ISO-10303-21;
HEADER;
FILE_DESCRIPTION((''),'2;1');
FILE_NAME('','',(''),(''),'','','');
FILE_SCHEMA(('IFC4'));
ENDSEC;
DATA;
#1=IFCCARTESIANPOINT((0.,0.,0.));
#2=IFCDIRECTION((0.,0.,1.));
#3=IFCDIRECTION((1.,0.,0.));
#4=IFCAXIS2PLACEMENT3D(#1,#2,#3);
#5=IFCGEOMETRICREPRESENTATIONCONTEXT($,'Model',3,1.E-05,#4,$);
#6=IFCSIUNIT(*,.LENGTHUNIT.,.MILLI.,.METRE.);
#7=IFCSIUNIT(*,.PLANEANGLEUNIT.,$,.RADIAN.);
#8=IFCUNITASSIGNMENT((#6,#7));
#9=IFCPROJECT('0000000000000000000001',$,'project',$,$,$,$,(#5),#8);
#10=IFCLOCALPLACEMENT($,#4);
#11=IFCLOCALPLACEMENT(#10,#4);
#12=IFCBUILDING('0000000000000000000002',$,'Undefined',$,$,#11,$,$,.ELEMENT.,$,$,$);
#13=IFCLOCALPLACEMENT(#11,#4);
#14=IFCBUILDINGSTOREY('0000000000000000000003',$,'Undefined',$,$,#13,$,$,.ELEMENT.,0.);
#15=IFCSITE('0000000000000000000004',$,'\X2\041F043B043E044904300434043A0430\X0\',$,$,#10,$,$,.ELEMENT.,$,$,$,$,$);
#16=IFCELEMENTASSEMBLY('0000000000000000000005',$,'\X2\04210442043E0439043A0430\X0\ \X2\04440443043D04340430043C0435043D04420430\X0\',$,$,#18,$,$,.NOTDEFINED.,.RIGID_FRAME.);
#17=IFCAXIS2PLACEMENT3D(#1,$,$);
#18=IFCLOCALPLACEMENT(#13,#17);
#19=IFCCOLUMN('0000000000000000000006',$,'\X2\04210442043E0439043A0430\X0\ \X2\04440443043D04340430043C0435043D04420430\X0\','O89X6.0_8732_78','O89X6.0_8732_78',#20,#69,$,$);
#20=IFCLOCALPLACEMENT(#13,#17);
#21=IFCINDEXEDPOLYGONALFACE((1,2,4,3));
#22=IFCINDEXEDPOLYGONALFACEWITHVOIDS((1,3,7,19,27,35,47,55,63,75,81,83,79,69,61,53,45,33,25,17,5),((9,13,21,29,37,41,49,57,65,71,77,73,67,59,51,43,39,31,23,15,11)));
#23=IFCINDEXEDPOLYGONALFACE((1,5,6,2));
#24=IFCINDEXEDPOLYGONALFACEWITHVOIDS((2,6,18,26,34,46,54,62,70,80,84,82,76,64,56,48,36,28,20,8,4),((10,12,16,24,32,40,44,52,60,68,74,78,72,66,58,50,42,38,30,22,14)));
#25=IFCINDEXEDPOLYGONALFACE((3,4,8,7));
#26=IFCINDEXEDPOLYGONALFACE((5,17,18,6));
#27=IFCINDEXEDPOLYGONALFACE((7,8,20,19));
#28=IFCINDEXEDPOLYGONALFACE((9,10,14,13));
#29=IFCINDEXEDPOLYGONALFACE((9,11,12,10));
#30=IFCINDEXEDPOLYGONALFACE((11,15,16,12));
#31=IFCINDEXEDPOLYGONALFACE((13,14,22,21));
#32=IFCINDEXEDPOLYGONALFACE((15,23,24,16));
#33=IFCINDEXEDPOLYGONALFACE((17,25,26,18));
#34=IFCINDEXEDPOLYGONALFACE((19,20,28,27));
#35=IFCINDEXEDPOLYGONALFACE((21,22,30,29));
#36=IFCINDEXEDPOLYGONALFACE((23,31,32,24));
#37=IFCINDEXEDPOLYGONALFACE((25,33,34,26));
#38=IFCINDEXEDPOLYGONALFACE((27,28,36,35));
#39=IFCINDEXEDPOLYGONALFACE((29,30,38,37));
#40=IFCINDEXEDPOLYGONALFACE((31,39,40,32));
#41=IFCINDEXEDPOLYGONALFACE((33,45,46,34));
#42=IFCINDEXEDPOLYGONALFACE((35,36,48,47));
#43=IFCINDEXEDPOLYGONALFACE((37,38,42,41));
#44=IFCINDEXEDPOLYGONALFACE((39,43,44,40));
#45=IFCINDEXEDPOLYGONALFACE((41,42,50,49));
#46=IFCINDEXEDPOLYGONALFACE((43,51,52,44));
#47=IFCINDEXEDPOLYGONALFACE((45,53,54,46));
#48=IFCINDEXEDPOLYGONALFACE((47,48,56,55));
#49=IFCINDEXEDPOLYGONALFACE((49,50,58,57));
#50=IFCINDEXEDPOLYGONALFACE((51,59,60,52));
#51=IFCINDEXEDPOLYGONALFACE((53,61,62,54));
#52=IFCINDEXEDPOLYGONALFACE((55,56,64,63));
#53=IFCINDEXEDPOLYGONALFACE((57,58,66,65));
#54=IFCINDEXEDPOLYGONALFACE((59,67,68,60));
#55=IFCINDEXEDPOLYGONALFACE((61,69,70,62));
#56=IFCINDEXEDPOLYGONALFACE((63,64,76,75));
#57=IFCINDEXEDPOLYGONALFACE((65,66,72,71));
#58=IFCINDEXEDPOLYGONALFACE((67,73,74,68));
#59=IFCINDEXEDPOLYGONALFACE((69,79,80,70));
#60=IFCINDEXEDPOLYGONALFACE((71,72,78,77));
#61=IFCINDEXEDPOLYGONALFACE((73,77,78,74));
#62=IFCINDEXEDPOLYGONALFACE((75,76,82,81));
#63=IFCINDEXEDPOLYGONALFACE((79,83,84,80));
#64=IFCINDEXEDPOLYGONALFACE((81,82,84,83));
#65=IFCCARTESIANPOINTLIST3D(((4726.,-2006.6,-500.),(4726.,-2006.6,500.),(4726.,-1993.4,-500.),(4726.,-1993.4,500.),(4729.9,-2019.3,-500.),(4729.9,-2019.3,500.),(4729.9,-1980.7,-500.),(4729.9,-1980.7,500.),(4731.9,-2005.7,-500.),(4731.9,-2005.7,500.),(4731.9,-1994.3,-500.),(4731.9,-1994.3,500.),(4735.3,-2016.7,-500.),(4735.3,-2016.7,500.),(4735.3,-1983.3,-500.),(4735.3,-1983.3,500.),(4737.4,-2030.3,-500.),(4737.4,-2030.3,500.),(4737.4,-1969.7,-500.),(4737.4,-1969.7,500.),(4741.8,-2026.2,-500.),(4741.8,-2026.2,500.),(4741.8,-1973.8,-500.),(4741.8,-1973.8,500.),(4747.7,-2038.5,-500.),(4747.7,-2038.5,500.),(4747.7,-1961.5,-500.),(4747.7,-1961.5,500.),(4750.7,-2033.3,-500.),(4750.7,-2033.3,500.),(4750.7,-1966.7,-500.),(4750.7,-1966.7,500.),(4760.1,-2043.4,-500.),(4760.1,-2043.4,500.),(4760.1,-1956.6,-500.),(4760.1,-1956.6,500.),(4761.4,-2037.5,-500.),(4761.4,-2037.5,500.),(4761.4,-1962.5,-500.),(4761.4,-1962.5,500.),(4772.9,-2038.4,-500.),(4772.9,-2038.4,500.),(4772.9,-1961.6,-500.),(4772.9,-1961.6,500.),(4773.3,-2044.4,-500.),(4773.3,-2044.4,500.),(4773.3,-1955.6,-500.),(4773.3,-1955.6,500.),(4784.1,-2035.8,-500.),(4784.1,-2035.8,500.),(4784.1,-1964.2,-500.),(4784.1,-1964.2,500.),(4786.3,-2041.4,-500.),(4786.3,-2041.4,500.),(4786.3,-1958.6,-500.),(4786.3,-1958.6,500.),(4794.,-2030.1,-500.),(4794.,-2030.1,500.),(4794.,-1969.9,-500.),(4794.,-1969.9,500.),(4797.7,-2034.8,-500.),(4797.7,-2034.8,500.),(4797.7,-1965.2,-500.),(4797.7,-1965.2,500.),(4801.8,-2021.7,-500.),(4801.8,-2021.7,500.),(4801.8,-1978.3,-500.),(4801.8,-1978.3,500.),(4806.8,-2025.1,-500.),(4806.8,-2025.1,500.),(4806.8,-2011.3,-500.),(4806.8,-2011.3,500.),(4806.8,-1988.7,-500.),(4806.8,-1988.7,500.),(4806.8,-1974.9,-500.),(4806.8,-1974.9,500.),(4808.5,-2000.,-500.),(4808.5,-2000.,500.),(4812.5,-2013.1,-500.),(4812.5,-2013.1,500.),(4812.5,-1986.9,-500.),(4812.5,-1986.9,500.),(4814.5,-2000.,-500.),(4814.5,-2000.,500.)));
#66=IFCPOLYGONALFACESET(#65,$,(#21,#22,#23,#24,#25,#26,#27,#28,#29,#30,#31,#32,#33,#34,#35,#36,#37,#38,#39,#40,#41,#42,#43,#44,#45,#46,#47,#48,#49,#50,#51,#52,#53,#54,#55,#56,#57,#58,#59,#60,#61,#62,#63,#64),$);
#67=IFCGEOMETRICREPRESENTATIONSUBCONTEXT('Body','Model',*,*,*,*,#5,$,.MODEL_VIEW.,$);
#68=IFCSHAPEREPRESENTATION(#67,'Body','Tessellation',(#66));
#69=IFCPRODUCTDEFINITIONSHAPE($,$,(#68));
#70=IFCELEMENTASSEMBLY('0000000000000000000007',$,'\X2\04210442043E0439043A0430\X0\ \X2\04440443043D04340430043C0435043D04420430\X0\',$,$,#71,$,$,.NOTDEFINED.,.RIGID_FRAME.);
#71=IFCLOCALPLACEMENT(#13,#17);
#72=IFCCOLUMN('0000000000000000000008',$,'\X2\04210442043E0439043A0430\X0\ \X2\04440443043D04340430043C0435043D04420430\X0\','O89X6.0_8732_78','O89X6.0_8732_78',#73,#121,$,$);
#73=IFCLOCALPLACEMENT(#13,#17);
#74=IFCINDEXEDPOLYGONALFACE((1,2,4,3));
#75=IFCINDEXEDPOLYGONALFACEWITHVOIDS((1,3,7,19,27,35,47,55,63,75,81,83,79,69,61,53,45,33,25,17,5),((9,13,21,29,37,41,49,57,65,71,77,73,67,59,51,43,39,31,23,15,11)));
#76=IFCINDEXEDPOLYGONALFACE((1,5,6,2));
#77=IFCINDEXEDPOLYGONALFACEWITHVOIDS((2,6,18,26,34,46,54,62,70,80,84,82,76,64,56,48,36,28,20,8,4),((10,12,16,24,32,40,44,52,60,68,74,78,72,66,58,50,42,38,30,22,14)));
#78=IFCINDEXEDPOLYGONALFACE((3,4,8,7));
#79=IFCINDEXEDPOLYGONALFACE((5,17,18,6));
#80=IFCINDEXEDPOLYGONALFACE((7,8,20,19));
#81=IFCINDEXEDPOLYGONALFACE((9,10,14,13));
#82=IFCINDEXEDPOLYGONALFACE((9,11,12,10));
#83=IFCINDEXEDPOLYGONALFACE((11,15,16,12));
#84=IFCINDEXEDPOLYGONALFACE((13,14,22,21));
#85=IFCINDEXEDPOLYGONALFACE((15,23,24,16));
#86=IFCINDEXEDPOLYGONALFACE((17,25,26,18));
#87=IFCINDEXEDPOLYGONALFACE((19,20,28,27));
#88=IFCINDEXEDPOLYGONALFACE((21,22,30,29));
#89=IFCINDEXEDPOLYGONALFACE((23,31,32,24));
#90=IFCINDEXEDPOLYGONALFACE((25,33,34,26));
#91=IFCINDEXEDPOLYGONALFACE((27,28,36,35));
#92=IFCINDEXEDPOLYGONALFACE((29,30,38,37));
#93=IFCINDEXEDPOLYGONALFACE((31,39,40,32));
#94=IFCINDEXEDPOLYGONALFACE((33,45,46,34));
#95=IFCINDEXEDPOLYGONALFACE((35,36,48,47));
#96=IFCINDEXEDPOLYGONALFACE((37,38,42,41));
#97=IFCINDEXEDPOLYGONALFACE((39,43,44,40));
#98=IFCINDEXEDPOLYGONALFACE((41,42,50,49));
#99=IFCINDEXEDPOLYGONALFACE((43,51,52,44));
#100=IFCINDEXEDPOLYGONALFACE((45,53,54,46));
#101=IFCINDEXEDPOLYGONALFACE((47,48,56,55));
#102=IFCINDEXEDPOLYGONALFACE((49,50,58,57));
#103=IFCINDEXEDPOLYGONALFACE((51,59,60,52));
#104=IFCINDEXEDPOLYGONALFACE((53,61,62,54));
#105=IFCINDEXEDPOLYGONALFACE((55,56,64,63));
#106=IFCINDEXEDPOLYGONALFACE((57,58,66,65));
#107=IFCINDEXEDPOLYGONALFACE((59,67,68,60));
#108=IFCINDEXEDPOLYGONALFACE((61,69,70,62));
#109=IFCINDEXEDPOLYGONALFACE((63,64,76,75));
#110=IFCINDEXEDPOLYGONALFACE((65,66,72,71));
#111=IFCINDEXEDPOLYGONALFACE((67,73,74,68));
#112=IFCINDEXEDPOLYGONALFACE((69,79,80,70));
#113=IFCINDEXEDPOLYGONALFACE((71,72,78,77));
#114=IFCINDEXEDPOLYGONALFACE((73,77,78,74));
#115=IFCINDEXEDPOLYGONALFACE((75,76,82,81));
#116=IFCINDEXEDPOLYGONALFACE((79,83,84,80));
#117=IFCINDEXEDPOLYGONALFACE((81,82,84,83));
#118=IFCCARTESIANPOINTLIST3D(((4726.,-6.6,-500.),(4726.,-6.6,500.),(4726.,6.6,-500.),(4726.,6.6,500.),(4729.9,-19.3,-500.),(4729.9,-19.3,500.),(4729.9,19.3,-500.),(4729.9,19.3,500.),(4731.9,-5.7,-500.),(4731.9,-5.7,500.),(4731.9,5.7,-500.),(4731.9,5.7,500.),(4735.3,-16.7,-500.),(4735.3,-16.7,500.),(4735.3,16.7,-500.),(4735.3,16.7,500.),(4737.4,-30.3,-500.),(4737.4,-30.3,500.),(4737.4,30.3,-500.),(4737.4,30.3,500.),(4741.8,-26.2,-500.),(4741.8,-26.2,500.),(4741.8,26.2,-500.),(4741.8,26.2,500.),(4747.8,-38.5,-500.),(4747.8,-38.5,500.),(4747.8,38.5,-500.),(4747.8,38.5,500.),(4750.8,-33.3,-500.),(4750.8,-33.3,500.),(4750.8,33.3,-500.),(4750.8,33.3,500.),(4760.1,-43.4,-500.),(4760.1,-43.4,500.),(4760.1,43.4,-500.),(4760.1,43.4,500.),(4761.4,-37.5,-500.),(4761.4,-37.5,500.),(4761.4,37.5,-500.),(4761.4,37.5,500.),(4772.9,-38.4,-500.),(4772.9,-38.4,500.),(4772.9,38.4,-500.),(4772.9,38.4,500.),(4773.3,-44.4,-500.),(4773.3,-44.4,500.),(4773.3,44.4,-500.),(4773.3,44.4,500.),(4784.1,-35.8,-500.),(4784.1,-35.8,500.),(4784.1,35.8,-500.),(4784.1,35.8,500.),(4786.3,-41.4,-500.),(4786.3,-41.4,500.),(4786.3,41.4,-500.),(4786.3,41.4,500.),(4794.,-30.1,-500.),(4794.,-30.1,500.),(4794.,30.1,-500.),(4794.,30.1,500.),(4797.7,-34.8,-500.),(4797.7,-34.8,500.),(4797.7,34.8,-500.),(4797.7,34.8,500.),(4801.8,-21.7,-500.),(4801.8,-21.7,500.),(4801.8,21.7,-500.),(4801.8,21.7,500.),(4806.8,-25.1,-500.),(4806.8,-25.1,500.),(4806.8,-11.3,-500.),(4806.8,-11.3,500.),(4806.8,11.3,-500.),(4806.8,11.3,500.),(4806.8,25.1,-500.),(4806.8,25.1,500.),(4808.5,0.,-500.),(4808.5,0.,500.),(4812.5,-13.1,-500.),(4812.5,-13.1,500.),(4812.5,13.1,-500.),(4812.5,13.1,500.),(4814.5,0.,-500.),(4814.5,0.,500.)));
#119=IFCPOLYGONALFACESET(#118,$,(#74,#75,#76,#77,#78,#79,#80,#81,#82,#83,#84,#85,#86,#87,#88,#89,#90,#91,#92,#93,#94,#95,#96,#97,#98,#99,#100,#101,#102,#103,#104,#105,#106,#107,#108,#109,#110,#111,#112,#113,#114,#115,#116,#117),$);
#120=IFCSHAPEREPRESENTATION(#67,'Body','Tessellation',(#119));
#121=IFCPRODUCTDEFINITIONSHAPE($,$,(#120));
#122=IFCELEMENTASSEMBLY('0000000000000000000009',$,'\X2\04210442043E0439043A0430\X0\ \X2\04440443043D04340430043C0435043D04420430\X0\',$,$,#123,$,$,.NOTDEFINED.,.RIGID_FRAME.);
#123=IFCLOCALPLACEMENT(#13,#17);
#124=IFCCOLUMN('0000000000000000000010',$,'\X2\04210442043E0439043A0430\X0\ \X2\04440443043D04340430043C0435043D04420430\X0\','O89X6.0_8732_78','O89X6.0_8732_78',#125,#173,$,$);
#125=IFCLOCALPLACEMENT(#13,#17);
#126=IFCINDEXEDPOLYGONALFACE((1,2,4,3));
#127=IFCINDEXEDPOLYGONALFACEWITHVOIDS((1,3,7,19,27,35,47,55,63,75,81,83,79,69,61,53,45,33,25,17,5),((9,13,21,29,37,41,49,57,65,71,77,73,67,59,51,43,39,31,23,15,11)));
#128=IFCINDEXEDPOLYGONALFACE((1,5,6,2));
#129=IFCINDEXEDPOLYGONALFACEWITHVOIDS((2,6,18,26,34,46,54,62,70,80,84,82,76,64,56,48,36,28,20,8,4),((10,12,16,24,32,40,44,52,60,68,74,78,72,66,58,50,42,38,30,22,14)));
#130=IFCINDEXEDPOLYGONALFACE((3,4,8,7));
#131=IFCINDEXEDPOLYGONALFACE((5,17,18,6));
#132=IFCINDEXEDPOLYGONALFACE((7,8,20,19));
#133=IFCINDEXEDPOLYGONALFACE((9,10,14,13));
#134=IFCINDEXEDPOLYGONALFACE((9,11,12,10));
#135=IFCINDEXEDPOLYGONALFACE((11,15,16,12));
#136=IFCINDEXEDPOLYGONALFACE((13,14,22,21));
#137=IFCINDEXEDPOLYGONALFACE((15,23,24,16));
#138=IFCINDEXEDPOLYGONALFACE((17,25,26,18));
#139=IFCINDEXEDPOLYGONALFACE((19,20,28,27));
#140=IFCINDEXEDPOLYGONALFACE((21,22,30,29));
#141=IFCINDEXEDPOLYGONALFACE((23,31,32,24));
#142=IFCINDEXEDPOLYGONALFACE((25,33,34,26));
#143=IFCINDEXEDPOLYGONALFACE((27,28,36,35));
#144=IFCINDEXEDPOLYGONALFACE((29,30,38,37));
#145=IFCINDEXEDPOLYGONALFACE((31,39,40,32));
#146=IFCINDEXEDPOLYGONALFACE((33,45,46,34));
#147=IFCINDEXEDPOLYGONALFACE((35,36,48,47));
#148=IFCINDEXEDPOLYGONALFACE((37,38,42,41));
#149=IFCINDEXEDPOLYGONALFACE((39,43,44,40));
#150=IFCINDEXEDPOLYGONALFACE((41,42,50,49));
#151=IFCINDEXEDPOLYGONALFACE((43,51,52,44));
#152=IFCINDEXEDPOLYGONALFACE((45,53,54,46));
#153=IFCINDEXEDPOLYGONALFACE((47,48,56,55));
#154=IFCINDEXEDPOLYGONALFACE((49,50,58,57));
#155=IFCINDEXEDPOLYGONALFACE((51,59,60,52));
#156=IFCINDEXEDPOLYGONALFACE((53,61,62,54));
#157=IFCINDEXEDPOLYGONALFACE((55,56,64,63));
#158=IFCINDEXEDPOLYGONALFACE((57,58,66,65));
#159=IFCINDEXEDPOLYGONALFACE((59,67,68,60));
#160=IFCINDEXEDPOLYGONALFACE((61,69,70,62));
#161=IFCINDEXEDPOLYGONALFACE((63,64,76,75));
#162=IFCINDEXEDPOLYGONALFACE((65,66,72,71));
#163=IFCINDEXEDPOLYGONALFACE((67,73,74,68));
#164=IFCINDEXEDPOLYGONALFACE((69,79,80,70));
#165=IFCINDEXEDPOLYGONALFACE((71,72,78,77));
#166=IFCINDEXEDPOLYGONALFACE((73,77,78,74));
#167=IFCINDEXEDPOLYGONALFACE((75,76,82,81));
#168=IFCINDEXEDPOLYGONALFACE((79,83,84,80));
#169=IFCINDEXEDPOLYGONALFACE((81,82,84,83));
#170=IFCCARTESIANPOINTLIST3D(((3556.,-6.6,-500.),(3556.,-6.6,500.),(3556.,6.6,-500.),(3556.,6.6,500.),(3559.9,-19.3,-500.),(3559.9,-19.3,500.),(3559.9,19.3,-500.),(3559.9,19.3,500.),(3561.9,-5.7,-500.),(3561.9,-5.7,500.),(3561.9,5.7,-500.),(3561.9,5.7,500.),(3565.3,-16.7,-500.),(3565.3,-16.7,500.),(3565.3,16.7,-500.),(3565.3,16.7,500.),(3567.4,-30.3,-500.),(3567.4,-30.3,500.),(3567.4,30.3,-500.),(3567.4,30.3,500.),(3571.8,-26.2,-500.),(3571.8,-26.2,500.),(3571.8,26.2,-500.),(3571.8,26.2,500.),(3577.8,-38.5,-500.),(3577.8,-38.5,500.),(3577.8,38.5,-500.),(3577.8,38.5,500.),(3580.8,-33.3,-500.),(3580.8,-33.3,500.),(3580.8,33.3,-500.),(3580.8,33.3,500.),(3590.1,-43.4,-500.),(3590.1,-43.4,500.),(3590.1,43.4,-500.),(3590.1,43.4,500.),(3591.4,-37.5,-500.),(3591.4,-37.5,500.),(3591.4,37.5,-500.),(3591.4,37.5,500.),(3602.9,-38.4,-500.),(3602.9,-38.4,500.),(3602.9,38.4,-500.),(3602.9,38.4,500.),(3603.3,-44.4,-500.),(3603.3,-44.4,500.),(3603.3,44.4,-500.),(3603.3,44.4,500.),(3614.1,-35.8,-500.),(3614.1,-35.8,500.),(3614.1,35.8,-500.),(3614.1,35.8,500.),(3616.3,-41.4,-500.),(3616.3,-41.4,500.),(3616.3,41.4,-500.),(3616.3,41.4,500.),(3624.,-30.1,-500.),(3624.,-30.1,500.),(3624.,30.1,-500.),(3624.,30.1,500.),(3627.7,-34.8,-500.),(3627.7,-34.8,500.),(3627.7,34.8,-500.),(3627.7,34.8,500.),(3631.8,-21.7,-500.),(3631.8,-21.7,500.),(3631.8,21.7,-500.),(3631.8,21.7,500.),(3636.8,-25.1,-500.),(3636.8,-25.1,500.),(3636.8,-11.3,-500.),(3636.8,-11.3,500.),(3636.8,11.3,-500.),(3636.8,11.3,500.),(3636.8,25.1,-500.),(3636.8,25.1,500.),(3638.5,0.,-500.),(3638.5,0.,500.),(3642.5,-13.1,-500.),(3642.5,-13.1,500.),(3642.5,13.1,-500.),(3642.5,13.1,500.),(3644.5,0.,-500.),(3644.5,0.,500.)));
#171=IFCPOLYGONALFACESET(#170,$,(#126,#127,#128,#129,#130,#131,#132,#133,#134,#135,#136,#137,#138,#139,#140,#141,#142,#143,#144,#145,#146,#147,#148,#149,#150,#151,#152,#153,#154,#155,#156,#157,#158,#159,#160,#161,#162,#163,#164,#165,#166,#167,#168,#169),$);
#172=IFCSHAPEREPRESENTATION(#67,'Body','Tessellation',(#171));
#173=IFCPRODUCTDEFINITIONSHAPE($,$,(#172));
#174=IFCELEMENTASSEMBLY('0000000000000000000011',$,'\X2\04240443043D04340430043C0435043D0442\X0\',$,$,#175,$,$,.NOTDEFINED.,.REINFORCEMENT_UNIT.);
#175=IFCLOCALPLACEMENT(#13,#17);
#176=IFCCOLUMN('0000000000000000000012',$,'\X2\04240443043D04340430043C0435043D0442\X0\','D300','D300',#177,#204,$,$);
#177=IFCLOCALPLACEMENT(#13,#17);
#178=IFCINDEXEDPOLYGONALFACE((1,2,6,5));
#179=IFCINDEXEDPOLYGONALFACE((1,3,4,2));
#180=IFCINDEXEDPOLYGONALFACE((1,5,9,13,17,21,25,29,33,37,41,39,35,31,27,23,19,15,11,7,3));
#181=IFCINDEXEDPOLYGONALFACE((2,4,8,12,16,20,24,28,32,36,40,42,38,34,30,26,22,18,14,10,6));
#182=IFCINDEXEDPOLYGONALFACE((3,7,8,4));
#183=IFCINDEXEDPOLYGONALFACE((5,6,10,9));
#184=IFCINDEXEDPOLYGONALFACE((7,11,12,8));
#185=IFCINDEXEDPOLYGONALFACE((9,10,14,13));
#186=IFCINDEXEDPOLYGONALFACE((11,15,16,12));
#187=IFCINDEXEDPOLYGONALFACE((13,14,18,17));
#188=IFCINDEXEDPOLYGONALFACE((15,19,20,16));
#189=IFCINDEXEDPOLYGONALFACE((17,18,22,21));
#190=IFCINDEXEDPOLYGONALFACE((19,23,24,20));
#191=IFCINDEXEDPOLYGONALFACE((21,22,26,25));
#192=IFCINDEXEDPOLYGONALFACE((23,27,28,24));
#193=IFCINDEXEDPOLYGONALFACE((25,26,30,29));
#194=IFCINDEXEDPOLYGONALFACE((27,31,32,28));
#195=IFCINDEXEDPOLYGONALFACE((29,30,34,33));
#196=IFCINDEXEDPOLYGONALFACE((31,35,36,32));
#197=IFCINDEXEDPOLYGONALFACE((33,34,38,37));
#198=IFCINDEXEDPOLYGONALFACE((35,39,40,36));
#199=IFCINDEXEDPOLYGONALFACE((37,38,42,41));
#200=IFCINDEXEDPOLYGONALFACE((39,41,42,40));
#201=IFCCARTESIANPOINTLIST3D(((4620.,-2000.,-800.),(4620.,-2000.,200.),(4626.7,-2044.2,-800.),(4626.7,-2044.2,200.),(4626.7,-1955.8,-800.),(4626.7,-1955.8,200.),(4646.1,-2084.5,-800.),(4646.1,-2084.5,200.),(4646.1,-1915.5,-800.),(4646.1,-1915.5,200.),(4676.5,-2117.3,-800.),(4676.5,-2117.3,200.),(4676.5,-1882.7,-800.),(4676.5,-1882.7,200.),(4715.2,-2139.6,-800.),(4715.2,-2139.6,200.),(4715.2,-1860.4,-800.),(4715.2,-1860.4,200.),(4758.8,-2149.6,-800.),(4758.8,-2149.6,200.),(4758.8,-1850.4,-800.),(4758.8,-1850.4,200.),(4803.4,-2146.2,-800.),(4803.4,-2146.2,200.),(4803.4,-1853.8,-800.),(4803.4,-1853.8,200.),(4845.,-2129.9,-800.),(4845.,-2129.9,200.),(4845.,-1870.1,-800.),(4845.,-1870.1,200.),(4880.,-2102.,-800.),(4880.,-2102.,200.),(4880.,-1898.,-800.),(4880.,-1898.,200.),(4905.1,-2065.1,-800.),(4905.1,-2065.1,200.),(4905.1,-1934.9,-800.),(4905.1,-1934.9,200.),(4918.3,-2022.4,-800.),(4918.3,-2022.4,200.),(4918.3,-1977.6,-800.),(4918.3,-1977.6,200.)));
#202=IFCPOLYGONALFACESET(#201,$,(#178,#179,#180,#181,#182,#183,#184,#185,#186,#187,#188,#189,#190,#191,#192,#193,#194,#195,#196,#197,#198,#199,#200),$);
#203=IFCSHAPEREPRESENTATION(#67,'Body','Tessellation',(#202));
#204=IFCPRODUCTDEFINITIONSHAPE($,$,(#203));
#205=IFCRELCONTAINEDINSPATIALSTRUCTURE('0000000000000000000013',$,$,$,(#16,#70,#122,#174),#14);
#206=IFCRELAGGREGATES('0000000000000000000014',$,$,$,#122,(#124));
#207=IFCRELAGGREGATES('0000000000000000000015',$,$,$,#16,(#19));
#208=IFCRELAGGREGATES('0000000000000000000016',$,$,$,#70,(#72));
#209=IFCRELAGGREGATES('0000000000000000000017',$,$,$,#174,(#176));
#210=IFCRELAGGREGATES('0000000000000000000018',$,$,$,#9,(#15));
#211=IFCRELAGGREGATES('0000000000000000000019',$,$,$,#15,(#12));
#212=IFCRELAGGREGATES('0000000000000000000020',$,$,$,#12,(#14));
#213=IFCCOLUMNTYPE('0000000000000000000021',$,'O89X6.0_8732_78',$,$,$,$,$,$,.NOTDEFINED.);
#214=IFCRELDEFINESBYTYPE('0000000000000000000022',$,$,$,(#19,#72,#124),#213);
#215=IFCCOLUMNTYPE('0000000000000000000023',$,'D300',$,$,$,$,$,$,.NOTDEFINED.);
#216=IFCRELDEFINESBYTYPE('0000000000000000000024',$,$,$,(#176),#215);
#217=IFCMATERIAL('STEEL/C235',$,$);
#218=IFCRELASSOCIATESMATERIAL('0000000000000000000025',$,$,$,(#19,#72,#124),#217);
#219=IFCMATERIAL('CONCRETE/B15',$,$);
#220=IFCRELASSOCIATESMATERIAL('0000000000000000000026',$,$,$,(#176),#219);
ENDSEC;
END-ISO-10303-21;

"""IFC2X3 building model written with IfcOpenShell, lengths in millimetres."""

from ifc_helpers import new_model, si_unit, frame, origin_with_axes, origin_2d_with_axis, place, context, subcontext, project, spatial, circle, hollow_circle, extrude, material, type_object, element, aggregate, save


model = new_model("IFC2X3")

# Units and contexts
model_context = context("Model", 3, precision=1e-05, world=origin_with_axes())
body_context = subcontext(model_context, "Body", "Model", "MODEL_VIEW")
ifc_project = project(units=[si_unit("LENGTHUNIT", "METRE", prefix="MILLI"), si_unit("PLANEANGLEUNIT", "RADIAN")], contexts=[model_context])

# Site, building, storey
site_placement = place(None, origin_with_axes())
site = spatial("IfcSite", under=ifc_project, at=site_placement, Name="Площадка", CompositionType="ELEMENT")
building_placement = place(site_placement, origin_with_axes())
building = spatial("IfcBuilding", under=site, at=building_placement, Name="Undefined", CompositionType="ELEMENT")
storey_placement = place(building_placement, origin_with_axes())
storey = spatial("IfcBuildingStorey", under=building, at=storey_placement, Name="Undefined", CompositionType="ELEMENT", Elevation=0.0)

# Element assemblies, columns
assembly_1_placement = place(storey_placement, origin_with_axes())
assembly_1 = element("IfcElementAssembly", 1, at=assembly_1_placement, inside=storey, Name="Стойка фундамента", AssemblyPlace="NOTDEFINED", PredefinedType="RIGID_FRAME")
ifc_material_1 = material(Name="STEEL/C235")
column_type_1 = type_object("IfcColumnType", Name="O89X6.0_8732_78", PredefinedType="NOTDEFINED")
column_1_placement = place(assembly_1_placement, frame((4770.0, -2000.0, -500.0), z_axis=(0.0, 0.0, 1.0), x_axis=(0.0, -1.0, 0.0)))
column_1 = element("IfcColumn", 2, at=column_1_placement, type_object=column_type_1, material=ifc_material_1, Name="Стойка фундамента", Description="O89X6.0_8732_78", ObjectType="O89X6.0_8732_78", context=body_context, shape_type="SweptSolid", body=[
    extrude(hollow_circle(Radius=44.5, WallThickness=6.0, at=origin_2d_with_axis()), frame((0.0, 0.0, 1000.0), z_axis=(0.0, 0.0, -1.0), x_axis=(0.0, 1.0, 0.0)), (0.0, 0.0, 1.0), 1000.0),
])
assembly_2_placement = place(storey_placement, origin_with_axes())
assembly_2 = element("IfcElementAssembly", 3, at=assembly_2_placement, inside=storey, Name="Стойка фундамента", AssemblyPlace="NOTDEFINED", PredefinedType="RIGID_FRAME")
column_2_placement = place(assembly_2_placement, frame((4770.0, 0.0, -500.0), z_axis=(0.0, 0.0, 1.0), x_axis=(0.0, -1.0, 0.0)))
column_2 = element("IfcColumn", 4, at=column_2_placement, type_object=column_type_1, material=ifc_material_1, Name="Стойка фундамента", Description="O89X6.0_8732_78", ObjectType="O89X6.0_8732_78", context=body_context, shape_type="SweptSolid", body=[
    extrude(hollow_circle(Radius=44.5, WallThickness=6.0, at=origin_2d_with_axis()), frame((0.0, 0.0, 1000.0), z_axis=(0.0, 0.0, -1.0), x_axis=(0.0, 1.0, 0.0)), (0.0, 0.0, 1.0), 1000.0),
])
assembly_3_placement = place(storey_placement, origin_with_axes())
assembly_3 = element("IfcElementAssembly", 5, at=assembly_3_placement, inside=storey, Name="Стойка фундамента", AssemblyPlace="NOTDEFINED", PredefinedType="RIGID_FRAME")
column_3_placement = place(assembly_3_placement, frame((3600.0, 0.0, -500.0), z_axis=(0.0, 0.0, 1.0), x_axis=(0.0, -1.0, 0.0)))
column_3 = element("IfcColumn", 6, at=column_3_placement, type_object=column_type_1, material=ifc_material_1, Name="Стойка фундамента", Description="O89X6.0_8732_78", ObjectType="O89X6.0_8732_78", context=body_context, shape_type="SweptSolid", body=[
    extrude(hollow_circle(Radius=44.5, WallThickness=6.0, at=origin_2d_with_axis()), frame((0.0, 0.0, 1000.0), z_axis=(0.0, 0.0, -1.0), x_axis=(0.0, 1.0, 0.0)), (0.0, 0.0, 1.0), 1000.0),
])
aggregate(assembly_3, [column_3])
assembly_4_placement = place(storey_placement, origin_with_axes())
assembly_4 = element("IfcElementAssembly", 7, at=assembly_4_placement, inside=storey, Name="Фундамент", AssemblyPlace="NOTDEFINED", PredefinedType="REINFORCEMENT_UNIT")
ifc_material_2 = material(Name="CONCRETE/B15")
column_type_2 = type_object("IfcColumnType", Name="D300", PredefinedType="NOTDEFINED")
column_4_placement = place(assembly_4_placement, frame((4770.0, -2000.0, -800.0), z_axis=(0.0, 0.0, 1.0), x_axis=(0.0, 1.0, 0.0)))
column_4 = element("IfcColumn", 8, at=column_4_placement, type_object=column_type_2, material=ifc_material_2, Name="Фундамент", Description="D300", ObjectType="D300", context=body_context, shape_type="SweptSolid", body=[
    extrude(circle(Radius=150.0, at=origin_2d_with_axis()), frame((0.0, 0.0, 1000.0), z_axis=(0.0, 0.0, -1.0), x_axis=(0.0, 1.0, 0.0)), (0.0, 0.0, 1.0), 1000.0),
])

aggregate(assembly_1, [column_1])
aggregate(assembly_2, [column_2])

aggregate(assembly_4, [column_4])

save(model, "model.ifc")
